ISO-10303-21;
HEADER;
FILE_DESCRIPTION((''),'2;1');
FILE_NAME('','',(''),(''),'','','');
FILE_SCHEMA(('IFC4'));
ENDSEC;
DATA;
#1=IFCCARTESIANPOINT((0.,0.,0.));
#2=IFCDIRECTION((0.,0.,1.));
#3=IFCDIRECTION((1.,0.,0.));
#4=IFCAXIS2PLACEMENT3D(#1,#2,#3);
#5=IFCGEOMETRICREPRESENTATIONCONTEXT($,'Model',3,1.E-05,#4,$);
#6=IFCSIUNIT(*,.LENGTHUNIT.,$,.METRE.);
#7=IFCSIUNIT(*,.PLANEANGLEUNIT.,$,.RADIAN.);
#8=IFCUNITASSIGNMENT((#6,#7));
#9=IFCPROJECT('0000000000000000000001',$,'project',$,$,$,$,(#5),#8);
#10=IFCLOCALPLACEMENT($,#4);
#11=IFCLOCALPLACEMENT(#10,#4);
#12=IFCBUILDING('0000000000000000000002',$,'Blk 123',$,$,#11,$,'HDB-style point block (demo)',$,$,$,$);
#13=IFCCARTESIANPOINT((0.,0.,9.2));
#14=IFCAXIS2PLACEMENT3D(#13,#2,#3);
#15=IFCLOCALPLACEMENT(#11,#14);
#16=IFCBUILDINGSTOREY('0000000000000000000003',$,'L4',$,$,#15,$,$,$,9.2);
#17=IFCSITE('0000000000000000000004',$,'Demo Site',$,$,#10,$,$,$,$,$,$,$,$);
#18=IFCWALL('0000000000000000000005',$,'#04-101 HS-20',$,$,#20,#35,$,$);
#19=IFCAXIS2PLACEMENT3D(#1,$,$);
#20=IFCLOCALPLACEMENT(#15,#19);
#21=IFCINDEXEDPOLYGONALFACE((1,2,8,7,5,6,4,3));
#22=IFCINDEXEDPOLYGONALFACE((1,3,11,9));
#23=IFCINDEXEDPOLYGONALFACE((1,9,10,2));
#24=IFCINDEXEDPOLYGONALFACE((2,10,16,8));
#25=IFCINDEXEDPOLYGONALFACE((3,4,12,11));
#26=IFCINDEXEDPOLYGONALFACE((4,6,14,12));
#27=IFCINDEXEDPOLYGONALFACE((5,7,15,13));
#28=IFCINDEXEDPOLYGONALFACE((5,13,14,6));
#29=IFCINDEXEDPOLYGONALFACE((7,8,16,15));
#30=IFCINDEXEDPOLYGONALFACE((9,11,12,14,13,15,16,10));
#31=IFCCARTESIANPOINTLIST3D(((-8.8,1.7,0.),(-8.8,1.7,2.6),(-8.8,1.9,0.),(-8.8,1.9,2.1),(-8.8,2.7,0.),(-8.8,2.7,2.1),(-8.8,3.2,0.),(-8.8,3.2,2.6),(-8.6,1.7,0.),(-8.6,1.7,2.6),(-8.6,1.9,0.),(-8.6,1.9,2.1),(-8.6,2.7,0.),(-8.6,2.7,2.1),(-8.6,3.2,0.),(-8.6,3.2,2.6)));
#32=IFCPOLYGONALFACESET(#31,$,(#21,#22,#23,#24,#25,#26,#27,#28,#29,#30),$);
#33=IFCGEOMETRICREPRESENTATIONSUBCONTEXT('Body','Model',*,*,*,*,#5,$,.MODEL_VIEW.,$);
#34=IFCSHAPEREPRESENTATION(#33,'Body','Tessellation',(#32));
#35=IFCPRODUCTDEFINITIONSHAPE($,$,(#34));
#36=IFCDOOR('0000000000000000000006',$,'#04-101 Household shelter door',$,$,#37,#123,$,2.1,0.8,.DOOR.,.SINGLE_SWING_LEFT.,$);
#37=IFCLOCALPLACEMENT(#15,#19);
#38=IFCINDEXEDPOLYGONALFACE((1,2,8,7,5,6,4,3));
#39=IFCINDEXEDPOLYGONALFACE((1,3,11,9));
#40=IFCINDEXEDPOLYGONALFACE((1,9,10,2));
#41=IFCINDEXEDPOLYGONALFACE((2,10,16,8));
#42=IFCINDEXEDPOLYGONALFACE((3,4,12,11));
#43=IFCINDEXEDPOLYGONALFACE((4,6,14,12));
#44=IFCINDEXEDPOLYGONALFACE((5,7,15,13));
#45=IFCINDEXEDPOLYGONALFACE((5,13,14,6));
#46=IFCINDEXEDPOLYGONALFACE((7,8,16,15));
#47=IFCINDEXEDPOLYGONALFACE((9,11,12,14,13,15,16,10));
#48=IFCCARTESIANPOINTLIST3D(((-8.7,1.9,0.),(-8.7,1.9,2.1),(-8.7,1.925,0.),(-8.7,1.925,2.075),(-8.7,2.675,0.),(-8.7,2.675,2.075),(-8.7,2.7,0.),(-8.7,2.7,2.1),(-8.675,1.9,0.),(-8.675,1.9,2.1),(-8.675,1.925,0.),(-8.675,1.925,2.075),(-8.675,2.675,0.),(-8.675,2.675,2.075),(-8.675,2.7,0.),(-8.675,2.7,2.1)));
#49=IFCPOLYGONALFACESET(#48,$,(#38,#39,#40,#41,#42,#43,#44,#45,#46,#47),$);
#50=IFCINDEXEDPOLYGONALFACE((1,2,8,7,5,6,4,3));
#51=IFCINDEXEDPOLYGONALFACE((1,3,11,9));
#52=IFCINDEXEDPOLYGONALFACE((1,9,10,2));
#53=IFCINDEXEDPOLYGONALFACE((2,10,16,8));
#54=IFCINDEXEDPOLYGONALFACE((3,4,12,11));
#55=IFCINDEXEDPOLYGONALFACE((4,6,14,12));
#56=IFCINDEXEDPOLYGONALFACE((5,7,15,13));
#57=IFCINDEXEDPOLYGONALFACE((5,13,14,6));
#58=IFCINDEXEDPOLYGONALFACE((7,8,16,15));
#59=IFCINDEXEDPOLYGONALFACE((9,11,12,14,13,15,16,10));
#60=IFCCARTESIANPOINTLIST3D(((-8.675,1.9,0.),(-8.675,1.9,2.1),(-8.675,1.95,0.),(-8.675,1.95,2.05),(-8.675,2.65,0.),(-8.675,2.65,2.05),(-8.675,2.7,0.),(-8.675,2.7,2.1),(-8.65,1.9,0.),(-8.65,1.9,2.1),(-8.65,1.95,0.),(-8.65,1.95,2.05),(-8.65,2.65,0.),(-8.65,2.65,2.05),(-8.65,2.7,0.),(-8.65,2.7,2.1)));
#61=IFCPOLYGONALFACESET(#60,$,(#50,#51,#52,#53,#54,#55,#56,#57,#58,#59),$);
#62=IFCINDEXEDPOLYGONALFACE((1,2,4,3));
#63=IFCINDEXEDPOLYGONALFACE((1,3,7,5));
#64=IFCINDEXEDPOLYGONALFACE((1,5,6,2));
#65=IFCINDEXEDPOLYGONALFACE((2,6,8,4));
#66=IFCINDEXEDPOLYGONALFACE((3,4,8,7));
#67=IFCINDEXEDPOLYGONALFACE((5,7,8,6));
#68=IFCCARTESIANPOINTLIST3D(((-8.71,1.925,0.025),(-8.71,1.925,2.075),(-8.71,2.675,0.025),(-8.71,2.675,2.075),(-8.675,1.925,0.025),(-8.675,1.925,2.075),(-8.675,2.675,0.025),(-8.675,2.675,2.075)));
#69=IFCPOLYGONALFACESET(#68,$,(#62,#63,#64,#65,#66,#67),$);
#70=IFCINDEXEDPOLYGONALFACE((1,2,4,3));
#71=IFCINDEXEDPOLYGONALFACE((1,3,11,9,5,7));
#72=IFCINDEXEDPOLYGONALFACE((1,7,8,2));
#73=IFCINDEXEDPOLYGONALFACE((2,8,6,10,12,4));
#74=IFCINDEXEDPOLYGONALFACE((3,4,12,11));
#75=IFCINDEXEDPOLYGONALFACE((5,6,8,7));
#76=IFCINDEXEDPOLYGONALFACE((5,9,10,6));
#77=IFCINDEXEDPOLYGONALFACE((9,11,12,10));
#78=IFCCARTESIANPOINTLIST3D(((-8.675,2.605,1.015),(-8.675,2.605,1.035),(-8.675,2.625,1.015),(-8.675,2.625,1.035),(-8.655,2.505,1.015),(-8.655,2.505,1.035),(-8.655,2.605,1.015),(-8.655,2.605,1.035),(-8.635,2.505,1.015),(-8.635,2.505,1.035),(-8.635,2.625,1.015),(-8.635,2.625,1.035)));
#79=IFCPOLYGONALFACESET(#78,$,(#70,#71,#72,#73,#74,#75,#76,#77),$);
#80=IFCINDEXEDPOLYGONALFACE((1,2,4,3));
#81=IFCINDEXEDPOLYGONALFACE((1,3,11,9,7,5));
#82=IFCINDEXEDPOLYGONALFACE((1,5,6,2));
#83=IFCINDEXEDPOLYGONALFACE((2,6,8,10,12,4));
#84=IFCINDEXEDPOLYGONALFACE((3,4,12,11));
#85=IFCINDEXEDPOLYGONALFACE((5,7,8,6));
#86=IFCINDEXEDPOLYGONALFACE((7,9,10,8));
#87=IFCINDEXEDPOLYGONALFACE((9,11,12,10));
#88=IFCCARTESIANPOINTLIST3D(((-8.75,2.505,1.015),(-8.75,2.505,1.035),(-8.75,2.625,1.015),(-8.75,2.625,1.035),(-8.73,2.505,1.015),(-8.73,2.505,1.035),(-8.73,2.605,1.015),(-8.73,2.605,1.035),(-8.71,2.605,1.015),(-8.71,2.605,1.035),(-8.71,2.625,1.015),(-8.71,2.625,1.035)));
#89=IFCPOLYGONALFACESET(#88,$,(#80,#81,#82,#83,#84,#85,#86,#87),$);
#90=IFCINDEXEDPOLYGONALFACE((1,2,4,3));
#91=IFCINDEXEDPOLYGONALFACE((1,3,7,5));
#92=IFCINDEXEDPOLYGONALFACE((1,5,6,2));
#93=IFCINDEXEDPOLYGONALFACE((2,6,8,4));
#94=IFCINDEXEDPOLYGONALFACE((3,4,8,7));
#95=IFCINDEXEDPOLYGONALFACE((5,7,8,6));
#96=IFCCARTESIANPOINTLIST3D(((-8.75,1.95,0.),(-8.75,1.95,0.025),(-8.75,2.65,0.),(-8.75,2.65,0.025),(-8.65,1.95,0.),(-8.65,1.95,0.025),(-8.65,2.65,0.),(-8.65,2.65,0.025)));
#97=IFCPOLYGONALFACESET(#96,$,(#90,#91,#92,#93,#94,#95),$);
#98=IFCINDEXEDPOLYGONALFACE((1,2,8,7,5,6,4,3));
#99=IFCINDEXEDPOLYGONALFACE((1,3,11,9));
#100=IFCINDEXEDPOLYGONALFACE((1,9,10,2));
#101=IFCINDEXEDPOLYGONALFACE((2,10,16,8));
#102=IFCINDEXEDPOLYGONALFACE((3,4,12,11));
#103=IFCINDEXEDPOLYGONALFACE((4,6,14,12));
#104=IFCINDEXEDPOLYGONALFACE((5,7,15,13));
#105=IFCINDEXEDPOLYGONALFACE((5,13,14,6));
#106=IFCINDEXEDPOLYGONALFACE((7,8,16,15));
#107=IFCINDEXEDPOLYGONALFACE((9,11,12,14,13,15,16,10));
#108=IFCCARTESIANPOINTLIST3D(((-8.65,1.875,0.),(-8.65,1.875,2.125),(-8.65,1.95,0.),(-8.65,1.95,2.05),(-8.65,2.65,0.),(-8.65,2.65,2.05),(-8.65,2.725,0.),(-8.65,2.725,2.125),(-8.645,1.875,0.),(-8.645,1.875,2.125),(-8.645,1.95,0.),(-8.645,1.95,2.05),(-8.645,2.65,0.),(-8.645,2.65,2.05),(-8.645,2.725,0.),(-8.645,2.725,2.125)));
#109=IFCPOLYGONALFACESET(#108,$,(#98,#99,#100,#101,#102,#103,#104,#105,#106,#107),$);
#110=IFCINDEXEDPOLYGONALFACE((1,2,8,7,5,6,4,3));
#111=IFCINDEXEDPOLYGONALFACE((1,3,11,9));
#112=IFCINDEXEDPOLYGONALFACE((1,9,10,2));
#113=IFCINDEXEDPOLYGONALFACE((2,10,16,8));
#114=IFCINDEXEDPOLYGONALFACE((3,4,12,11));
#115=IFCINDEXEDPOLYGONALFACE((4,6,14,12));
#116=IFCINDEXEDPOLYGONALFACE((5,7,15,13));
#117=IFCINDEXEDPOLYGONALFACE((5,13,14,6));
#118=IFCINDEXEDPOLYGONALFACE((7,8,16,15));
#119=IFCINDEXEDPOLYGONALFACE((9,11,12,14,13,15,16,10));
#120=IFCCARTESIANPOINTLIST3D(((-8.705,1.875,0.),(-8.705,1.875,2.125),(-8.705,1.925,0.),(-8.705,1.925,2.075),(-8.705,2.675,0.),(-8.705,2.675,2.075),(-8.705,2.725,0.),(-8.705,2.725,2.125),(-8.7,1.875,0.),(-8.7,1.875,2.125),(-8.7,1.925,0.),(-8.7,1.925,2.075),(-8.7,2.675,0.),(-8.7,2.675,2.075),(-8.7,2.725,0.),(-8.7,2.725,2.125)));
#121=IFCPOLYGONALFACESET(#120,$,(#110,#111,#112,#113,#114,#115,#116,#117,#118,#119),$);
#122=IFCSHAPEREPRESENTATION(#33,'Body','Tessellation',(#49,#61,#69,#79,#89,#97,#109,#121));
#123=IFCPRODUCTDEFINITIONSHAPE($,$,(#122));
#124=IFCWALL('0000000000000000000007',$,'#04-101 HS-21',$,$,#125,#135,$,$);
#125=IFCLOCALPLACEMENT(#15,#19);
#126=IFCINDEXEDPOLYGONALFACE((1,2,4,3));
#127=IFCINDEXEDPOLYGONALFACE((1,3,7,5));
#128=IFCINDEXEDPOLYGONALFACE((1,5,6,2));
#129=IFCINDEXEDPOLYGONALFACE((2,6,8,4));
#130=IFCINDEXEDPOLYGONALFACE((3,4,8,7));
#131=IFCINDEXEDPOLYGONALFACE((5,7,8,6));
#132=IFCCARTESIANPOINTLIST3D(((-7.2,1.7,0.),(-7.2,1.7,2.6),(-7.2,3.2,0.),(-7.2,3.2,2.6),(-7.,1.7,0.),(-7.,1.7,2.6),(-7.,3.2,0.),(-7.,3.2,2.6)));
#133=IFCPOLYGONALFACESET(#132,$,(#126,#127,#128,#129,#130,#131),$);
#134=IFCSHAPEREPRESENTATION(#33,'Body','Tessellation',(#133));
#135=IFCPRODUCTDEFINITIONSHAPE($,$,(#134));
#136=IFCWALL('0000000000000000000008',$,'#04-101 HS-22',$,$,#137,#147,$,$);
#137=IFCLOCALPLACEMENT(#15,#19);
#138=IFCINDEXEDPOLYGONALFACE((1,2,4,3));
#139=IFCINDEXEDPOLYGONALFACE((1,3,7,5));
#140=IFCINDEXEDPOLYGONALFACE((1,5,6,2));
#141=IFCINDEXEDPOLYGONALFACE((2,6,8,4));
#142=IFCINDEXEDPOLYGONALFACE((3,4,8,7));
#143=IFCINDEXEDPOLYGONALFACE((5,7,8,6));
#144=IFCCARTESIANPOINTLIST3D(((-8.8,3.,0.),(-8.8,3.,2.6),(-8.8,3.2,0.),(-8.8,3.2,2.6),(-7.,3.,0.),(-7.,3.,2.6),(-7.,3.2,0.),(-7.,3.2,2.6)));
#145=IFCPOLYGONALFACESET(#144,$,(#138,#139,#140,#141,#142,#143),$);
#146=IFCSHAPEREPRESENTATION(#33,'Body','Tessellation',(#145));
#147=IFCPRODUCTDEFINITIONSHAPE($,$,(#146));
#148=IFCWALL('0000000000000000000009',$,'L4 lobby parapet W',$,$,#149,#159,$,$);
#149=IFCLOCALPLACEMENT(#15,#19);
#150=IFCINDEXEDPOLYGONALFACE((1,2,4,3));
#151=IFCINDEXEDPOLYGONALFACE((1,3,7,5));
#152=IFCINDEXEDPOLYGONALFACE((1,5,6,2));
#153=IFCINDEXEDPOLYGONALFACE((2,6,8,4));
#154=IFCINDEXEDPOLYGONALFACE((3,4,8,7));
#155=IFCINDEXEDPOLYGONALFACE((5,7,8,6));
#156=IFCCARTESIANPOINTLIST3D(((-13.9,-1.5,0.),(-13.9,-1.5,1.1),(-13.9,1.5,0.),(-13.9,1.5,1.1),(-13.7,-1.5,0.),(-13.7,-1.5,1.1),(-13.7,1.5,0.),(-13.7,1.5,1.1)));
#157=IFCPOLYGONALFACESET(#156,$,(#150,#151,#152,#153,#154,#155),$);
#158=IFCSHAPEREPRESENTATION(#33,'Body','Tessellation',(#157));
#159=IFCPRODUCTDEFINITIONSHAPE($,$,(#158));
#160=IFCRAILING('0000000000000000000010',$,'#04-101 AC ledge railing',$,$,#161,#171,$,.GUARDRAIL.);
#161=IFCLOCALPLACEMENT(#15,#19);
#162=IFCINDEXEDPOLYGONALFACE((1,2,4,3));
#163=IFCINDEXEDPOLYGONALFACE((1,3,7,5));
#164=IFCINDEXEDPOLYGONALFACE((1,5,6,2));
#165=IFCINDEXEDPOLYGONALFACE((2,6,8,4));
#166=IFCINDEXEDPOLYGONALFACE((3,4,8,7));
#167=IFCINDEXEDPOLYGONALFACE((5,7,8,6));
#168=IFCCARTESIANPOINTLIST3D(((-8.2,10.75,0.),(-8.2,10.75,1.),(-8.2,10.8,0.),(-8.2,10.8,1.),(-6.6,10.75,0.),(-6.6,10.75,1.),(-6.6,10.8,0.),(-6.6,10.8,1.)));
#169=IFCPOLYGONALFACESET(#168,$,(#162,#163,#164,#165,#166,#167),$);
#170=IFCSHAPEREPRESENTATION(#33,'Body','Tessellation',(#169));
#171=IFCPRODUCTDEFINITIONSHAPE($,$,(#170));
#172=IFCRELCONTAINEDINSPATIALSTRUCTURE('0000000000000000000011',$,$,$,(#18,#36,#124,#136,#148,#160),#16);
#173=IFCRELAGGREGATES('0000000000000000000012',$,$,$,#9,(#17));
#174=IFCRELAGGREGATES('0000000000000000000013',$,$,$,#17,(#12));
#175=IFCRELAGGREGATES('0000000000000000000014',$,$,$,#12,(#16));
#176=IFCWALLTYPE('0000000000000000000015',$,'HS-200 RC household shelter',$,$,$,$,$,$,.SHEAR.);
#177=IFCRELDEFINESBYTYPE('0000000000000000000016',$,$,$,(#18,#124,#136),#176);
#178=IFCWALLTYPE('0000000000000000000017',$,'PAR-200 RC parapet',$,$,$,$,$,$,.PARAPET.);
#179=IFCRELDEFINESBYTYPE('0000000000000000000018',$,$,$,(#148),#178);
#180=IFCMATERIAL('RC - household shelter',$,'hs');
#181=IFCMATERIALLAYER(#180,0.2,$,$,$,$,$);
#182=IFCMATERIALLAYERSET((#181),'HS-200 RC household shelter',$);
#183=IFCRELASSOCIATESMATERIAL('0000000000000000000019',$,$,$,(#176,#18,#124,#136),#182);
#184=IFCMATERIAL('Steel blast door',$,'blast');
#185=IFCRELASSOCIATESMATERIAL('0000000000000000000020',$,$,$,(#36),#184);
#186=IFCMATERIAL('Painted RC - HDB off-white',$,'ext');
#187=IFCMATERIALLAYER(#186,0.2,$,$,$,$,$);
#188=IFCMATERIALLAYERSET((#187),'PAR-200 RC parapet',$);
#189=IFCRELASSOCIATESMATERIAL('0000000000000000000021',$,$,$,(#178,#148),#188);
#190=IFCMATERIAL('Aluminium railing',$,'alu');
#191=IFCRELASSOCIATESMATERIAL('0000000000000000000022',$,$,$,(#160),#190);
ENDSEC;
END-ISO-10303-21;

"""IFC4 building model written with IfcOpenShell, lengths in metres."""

from ifc_helpers import new_model, si_unit, frame, origin, origin_with_axes, place, context, subcontext, project, spatial, polyline, line, indexed_curve, outline, extrude, material, layer, layer_set, layer_usage, type_object, element, fill, save


model = new_model("IFC4")

# Units and contexts
model_context = context("Model", 3, precision=1e-05, world=origin_with_axes())
body_context = subcontext(model_context, "Body", "Model", "MODEL_VIEW")
ifc_project = project(units=[si_unit("LENGTHUNIT", "METRE"), si_unit("PLANEANGLEUNIT", "RADIAN")], contexts=[model_context])

# Site, building, storey
site_placement = place(None, origin_with_axes())
site = spatial("IfcSite", under=ifc_project, at=site_placement, Name="Demo Site")
building_placement = place(site_placement, origin_with_axes())
building = spatial("IfcBuilding", under=site, at=building_placement, Name="Blk 123", LongName="HDB-style point block (demo)")
storey_placement = place(building_placement, frame((0.0, 0.0, 9.2), z_axis=(0.0, 0.0, 1.0), x_axis=(1.0, 0.0, 0.0)))
storey = spatial("IfcBuildingStorey", under=building, at=storey_placement, Name="L4", Elevation=9.2)

# Shared definitions
ifc_material_1 = material(Name="Painted RC - HDB off-white", Category="ext")

# Wall, opening, door
ifc_material_2 = material(Name="RC - household shelter", Category="hs")
ifc_layer_1 = layer(ifc_material_2, 0.2)
ifc_layer_set_1 = layer_set([ifc_layer_1], Name="HS-200 RC household shelter")
ifc_layer_usage_1 = layer_usage(ifc_layer_set_1, "AXIS2", "POSITIVE", -0.1)
wall_type_1 = type_object("IfcWallType", Name="HS-200 RC household shelter", PredefinedType="SHEAR", material=ifc_layer_set_1)
wall_1_placement = place(storey_placement, frame((-8.7, 1.7, 0.0), z_axis=(0.0, 0.0, 1.0), x_axis=(0.0, 1.0, 0.0)))
wall_1 = element("IfcWall", 1, at=wall_1_placement, inside=storey, type_object=wall_type_1, material=ifc_layer_usage_1, Name="#04-101 HS-20", context=body_context, shape_type="SweptSolid", body=[
    extrude(outline(indexed_curve([(0.0, 0.0), (0.0, 0.2), (1.5, 0.2), (1.5, 0.0), (0.0, 0.0)], self_intersect=False)), frame((0.0, -0.1, 0.0), z_axis=(0.0, 0.0, 1.0), x_axis=(1.0, 0.0, 0.0)), (0.0, 0.0, 1.0), 2.6),
])
opening_1_placement = place(wall_1_placement, frame((0.2, -0.2, 0.0), z_axis=(0.0, 0.0, 1.0), x_axis=(1.0, 0.0, 0.0)))
opening_1 = element("IfcOpeningElement", 2, at=opening_1_placement, cuts=wall_1, context=body_context, shape_type="SweptSolid", body=[
    extrude(outline(indexed_curve([(0.0, 0.0), (0.0, 0.4), (0.8, 0.4), (0.8, 0.0), (0.0, 0.0)], self_intersect=False)), origin_with_axes(), (0.0, 0.0, 1.0), 2.1),
])
ifc_material_3 = material(Name="Steel blast door", Category="blast")
door_1_placement = place(opening_1_placement, frame((0.0, 0.15, 0.0), z_axis=(0.0, 0.0, 1.0), x_axis=(1.0, 0.0, 0.0)))
door_1 = element("IfcDoor", 3, at=door_1_placement, inside=storey, material=ifc_material_3, Name="#04-101 Household shelter door", OperationType="SINGLE_SWING_LEFT", OverallHeight=2.1, OverallWidth=0.8, PredefinedType="DOOR", context=body_context, shape_type="SweptSolid", body=[
    extrude(outline(indexed_curve([(0.0, 0.0), (0.0, 2.1), (0.8, 2.1), (0.8, 0.0), (0.775, 0.0), (0.775, 2.075), (0.025, 2.075), (0.025, 0.0)], segments=[line(1, 2, 3, 4, 5, 6, 7, 8, 1)])), frame((0.0, 0.025, 0.0), z_axis=(0.0, -1.0, 0.0), x_axis=(1.0, 0.0, 0.0)), (0.0, 0.0, -1.0), 0.025),
    extrude(outline(indexed_curve([(0.0, 0.0), (0.0, 2.1), (0.8, 2.1), (0.8, 0.0), (0.75, 0.0), (0.75, 2.05), (0.05, 2.05), (0.05, 0.0)], segments=[line(1, 2, 3, 4, 5, 6, 7, 8, 1)])), frame((0.0, 0.0, 0.0), z_axis=(0.0, -1.0, 0.0), x_axis=(1.0, 0.0, 0.0)), (0.0, 0.0, -1.0), 0.025),
    extrude(outline(indexed_curve([(0.0, 0.0), (0.75, 0.0), (0.75, 0.035), (0.0, 0.035)], segments=[line(1, 2, 3, 4, 1)])), frame((0.025, 0.025, 0.025), z_axis=(0.0, 0.0, 1.0), x_axis=(1.0, 0.0, 0.0)), (0.0, 0.0, 1.0), 2.05),
    extrude(outline(indexed_curve([(0.0, 0.0), (0.0, -0.04), (-0.12, -0.04), (-0.12, -0.02), (-0.02, -0.02), (-0.02, 0.0)], segments=[line(1, 2, 3, 4, 5, 6, 1)])), frame((0.725, 0.025, 1.015), z_axis=(0.0, 0.0, 1.0), x_axis=(1.0, 0.0, 0.0)), (0.0, 0.0, 1.0), 0.02),
    extrude(outline(indexed_curve([(0.0, 0.0), (0.0, 0.04), (-0.12, 0.04), (-0.12, 0.02), (-0.02, 0.02), (-0.02, 0.0)], segments=[line(1, 2, 3, 4, 5, 6, 1)])), frame((0.725, 0.06, 1.015), z_axis=(0.0, 0.0, 1.0), x_axis=(1.0, 0.0, 0.0)), (0.0, 0.0, 1.0), 0.02),
    extrude(outline(indexed_curve([(0.0, 0.0), (0.7, 0.0), (0.7, 0.1), (0.0, 0.1)], segments=[line(1, 2, 3, 4, 1)])), frame((0.05, 0.0, 0.0), z_axis=(0.0, 0.0, 1.0), x_axis=(1.0, 0.0, 0.0)), (0.0, 0.0, 1.0), 0.025),
    extrude(outline(indexed_curve([(0.0, 0.0), (0.0, 2.125), (0.85, 2.125), (0.85, 0.0), (0.775, 0.0), (0.775, 2.05), (0.075, 2.05), (0.075, 0.0)], segments=[line(1, 2, 3, 4, 5, 6, 7, 8, 1)])), frame((-0.025, -0.005, 0.0), z_axis=(0.0, -1.0, 0.0), x_axis=(1.0, 0.0, 0.0)), (0.0, 0.0, -1.0), 0.005),
    extrude(outline(indexed_curve([(0.0, 0.0), (0.0, 2.125), (0.85, 2.125), (0.85, 0.0), (0.8, 0.0), (0.8, 2.075), (0.05, 2.075), (0.05, 0.0)], segments=[line(1, 2, 3, 4, 5, 6, 7, 8, 1)])), frame((-0.025, 0.05, 0.0), z_axis=(0.0, -1.0, 0.0), x_axis=(1.0, 0.0, 0.0)), (0.0, 0.0, -1.0), 0.005),
])
fill(opening_1, door_1)

# Walls
wall_2_placement = place(storey_placement, frame((-7.1, 1.7, 0.0), z_axis=(0.0, 0.0, 1.0), x_axis=(0.0, 1.0, 0.0)))
element("IfcWall", 4, at=wall_2_placement, inside=storey, type_object=wall_type_1, material=ifc_layer_usage_1, Name="#04-101 HS-21", context=body_context, shape_type="SweptSolid", body=[
    extrude(outline(indexed_curve([(0.0, 0.0), (0.0, 0.2), (1.5, 0.2), (1.5, 0.0), (0.0, 0.0)], self_intersect=False)), frame((0.0, -0.1, 0.0), z_axis=(0.0, 0.0, 1.0), x_axis=(1.0, 0.0, 0.0)), (0.0, 0.0, 1.0), 2.6),
])
wall_3_placement = place(storey_placement, frame((-7.0, 3.1, 0.0), z_axis=(0.0, 0.0, 1.0), x_axis=(-1.0, 0.0, 0.0)))
element("IfcWall", 5, at=wall_3_placement, inside=storey, type_object=wall_type_1, material=ifc_layer_usage_1, Name="#04-101 HS-22", context=body_context, shape_type="SweptSolid", body=[
    extrude(outline(indexed_curve([(0.0, 0.0), (0.0, 0.2), (1.8, 0.2), (1.8, 0.0), (0.0, 0.0)], self_intersect=False)), frame((0.0, -0.1, 0.0), z_axis=(0.0, 0.0, 1.0), x_axis=(1.0, 0.0, 0.0)), (0.0, 0.0, 1.0), 2.6),
])
ifc_layer_2 = layer(ifc_material_1, 0.2)
ifc_layer_set_2 = layer_set([ifc_layer_2], Name="PAR-200 RC parapet")
ifc_layer_usage_2 = layer_usage(ifc_layer_set_2, "AXIS2", "POSITIVE", 0.0)
wall_type_2 = type_object("IfcWallType", Name="PAR-200 RC parapet", PredefinedType="PARAPET", material=ifc_layer_set_2)
wall_4_placement = place(storey_placement, frame((-13.9, 1.5, 0.0), z_axis=(0.0, 0.0, 1.0), x_axis=(0.0, -1.0, 0.0)))
element("IfcWall", 6, at=wall_4_placement, inside=storey, type_object=wall_type_2, material=ifc_layer_usage_2, Name="L4 lobby parapet W", context=body_context, shape_type="SweptSolid", body=[
    extrude(outline(indexed_curve([(0.0, 0.0), (0.0, 0.2), (3.0, 0.2), (3.0, 0.0), (0.0, 0.0)], self_intersect=False)), origin_with_axes(), (0.0, 0.0, 1.0), 1.1),
])

# Railing
ifc_material_4 = material(Name="Aluminium railing", Category="alu")
railing_placement = place(storey_placement, frame((-7.4, 10.775, 0.0), z_axis=(0.0, 0.0, 1.0), x_axis=(1.0, 0.0, 0.0)))
element("IfcRailing", 7, at=railing_placement, inside=storey, material=ifc_material_4, Name="#04-101 AC ledge railing", PredefinedType="GUARDRAIL", context=body_context, shape_type="SweptSolid", body=[
    extrude(outline(polyline([(-0.8, -0.025), (0.8, -0.025), (0.8, 0.025), (-0.8, 0.025), (-0.8, -0.025)])), origin(), (0.0, 0.0, 1.0), 1.0),
])

save(model, "model.ifc")
